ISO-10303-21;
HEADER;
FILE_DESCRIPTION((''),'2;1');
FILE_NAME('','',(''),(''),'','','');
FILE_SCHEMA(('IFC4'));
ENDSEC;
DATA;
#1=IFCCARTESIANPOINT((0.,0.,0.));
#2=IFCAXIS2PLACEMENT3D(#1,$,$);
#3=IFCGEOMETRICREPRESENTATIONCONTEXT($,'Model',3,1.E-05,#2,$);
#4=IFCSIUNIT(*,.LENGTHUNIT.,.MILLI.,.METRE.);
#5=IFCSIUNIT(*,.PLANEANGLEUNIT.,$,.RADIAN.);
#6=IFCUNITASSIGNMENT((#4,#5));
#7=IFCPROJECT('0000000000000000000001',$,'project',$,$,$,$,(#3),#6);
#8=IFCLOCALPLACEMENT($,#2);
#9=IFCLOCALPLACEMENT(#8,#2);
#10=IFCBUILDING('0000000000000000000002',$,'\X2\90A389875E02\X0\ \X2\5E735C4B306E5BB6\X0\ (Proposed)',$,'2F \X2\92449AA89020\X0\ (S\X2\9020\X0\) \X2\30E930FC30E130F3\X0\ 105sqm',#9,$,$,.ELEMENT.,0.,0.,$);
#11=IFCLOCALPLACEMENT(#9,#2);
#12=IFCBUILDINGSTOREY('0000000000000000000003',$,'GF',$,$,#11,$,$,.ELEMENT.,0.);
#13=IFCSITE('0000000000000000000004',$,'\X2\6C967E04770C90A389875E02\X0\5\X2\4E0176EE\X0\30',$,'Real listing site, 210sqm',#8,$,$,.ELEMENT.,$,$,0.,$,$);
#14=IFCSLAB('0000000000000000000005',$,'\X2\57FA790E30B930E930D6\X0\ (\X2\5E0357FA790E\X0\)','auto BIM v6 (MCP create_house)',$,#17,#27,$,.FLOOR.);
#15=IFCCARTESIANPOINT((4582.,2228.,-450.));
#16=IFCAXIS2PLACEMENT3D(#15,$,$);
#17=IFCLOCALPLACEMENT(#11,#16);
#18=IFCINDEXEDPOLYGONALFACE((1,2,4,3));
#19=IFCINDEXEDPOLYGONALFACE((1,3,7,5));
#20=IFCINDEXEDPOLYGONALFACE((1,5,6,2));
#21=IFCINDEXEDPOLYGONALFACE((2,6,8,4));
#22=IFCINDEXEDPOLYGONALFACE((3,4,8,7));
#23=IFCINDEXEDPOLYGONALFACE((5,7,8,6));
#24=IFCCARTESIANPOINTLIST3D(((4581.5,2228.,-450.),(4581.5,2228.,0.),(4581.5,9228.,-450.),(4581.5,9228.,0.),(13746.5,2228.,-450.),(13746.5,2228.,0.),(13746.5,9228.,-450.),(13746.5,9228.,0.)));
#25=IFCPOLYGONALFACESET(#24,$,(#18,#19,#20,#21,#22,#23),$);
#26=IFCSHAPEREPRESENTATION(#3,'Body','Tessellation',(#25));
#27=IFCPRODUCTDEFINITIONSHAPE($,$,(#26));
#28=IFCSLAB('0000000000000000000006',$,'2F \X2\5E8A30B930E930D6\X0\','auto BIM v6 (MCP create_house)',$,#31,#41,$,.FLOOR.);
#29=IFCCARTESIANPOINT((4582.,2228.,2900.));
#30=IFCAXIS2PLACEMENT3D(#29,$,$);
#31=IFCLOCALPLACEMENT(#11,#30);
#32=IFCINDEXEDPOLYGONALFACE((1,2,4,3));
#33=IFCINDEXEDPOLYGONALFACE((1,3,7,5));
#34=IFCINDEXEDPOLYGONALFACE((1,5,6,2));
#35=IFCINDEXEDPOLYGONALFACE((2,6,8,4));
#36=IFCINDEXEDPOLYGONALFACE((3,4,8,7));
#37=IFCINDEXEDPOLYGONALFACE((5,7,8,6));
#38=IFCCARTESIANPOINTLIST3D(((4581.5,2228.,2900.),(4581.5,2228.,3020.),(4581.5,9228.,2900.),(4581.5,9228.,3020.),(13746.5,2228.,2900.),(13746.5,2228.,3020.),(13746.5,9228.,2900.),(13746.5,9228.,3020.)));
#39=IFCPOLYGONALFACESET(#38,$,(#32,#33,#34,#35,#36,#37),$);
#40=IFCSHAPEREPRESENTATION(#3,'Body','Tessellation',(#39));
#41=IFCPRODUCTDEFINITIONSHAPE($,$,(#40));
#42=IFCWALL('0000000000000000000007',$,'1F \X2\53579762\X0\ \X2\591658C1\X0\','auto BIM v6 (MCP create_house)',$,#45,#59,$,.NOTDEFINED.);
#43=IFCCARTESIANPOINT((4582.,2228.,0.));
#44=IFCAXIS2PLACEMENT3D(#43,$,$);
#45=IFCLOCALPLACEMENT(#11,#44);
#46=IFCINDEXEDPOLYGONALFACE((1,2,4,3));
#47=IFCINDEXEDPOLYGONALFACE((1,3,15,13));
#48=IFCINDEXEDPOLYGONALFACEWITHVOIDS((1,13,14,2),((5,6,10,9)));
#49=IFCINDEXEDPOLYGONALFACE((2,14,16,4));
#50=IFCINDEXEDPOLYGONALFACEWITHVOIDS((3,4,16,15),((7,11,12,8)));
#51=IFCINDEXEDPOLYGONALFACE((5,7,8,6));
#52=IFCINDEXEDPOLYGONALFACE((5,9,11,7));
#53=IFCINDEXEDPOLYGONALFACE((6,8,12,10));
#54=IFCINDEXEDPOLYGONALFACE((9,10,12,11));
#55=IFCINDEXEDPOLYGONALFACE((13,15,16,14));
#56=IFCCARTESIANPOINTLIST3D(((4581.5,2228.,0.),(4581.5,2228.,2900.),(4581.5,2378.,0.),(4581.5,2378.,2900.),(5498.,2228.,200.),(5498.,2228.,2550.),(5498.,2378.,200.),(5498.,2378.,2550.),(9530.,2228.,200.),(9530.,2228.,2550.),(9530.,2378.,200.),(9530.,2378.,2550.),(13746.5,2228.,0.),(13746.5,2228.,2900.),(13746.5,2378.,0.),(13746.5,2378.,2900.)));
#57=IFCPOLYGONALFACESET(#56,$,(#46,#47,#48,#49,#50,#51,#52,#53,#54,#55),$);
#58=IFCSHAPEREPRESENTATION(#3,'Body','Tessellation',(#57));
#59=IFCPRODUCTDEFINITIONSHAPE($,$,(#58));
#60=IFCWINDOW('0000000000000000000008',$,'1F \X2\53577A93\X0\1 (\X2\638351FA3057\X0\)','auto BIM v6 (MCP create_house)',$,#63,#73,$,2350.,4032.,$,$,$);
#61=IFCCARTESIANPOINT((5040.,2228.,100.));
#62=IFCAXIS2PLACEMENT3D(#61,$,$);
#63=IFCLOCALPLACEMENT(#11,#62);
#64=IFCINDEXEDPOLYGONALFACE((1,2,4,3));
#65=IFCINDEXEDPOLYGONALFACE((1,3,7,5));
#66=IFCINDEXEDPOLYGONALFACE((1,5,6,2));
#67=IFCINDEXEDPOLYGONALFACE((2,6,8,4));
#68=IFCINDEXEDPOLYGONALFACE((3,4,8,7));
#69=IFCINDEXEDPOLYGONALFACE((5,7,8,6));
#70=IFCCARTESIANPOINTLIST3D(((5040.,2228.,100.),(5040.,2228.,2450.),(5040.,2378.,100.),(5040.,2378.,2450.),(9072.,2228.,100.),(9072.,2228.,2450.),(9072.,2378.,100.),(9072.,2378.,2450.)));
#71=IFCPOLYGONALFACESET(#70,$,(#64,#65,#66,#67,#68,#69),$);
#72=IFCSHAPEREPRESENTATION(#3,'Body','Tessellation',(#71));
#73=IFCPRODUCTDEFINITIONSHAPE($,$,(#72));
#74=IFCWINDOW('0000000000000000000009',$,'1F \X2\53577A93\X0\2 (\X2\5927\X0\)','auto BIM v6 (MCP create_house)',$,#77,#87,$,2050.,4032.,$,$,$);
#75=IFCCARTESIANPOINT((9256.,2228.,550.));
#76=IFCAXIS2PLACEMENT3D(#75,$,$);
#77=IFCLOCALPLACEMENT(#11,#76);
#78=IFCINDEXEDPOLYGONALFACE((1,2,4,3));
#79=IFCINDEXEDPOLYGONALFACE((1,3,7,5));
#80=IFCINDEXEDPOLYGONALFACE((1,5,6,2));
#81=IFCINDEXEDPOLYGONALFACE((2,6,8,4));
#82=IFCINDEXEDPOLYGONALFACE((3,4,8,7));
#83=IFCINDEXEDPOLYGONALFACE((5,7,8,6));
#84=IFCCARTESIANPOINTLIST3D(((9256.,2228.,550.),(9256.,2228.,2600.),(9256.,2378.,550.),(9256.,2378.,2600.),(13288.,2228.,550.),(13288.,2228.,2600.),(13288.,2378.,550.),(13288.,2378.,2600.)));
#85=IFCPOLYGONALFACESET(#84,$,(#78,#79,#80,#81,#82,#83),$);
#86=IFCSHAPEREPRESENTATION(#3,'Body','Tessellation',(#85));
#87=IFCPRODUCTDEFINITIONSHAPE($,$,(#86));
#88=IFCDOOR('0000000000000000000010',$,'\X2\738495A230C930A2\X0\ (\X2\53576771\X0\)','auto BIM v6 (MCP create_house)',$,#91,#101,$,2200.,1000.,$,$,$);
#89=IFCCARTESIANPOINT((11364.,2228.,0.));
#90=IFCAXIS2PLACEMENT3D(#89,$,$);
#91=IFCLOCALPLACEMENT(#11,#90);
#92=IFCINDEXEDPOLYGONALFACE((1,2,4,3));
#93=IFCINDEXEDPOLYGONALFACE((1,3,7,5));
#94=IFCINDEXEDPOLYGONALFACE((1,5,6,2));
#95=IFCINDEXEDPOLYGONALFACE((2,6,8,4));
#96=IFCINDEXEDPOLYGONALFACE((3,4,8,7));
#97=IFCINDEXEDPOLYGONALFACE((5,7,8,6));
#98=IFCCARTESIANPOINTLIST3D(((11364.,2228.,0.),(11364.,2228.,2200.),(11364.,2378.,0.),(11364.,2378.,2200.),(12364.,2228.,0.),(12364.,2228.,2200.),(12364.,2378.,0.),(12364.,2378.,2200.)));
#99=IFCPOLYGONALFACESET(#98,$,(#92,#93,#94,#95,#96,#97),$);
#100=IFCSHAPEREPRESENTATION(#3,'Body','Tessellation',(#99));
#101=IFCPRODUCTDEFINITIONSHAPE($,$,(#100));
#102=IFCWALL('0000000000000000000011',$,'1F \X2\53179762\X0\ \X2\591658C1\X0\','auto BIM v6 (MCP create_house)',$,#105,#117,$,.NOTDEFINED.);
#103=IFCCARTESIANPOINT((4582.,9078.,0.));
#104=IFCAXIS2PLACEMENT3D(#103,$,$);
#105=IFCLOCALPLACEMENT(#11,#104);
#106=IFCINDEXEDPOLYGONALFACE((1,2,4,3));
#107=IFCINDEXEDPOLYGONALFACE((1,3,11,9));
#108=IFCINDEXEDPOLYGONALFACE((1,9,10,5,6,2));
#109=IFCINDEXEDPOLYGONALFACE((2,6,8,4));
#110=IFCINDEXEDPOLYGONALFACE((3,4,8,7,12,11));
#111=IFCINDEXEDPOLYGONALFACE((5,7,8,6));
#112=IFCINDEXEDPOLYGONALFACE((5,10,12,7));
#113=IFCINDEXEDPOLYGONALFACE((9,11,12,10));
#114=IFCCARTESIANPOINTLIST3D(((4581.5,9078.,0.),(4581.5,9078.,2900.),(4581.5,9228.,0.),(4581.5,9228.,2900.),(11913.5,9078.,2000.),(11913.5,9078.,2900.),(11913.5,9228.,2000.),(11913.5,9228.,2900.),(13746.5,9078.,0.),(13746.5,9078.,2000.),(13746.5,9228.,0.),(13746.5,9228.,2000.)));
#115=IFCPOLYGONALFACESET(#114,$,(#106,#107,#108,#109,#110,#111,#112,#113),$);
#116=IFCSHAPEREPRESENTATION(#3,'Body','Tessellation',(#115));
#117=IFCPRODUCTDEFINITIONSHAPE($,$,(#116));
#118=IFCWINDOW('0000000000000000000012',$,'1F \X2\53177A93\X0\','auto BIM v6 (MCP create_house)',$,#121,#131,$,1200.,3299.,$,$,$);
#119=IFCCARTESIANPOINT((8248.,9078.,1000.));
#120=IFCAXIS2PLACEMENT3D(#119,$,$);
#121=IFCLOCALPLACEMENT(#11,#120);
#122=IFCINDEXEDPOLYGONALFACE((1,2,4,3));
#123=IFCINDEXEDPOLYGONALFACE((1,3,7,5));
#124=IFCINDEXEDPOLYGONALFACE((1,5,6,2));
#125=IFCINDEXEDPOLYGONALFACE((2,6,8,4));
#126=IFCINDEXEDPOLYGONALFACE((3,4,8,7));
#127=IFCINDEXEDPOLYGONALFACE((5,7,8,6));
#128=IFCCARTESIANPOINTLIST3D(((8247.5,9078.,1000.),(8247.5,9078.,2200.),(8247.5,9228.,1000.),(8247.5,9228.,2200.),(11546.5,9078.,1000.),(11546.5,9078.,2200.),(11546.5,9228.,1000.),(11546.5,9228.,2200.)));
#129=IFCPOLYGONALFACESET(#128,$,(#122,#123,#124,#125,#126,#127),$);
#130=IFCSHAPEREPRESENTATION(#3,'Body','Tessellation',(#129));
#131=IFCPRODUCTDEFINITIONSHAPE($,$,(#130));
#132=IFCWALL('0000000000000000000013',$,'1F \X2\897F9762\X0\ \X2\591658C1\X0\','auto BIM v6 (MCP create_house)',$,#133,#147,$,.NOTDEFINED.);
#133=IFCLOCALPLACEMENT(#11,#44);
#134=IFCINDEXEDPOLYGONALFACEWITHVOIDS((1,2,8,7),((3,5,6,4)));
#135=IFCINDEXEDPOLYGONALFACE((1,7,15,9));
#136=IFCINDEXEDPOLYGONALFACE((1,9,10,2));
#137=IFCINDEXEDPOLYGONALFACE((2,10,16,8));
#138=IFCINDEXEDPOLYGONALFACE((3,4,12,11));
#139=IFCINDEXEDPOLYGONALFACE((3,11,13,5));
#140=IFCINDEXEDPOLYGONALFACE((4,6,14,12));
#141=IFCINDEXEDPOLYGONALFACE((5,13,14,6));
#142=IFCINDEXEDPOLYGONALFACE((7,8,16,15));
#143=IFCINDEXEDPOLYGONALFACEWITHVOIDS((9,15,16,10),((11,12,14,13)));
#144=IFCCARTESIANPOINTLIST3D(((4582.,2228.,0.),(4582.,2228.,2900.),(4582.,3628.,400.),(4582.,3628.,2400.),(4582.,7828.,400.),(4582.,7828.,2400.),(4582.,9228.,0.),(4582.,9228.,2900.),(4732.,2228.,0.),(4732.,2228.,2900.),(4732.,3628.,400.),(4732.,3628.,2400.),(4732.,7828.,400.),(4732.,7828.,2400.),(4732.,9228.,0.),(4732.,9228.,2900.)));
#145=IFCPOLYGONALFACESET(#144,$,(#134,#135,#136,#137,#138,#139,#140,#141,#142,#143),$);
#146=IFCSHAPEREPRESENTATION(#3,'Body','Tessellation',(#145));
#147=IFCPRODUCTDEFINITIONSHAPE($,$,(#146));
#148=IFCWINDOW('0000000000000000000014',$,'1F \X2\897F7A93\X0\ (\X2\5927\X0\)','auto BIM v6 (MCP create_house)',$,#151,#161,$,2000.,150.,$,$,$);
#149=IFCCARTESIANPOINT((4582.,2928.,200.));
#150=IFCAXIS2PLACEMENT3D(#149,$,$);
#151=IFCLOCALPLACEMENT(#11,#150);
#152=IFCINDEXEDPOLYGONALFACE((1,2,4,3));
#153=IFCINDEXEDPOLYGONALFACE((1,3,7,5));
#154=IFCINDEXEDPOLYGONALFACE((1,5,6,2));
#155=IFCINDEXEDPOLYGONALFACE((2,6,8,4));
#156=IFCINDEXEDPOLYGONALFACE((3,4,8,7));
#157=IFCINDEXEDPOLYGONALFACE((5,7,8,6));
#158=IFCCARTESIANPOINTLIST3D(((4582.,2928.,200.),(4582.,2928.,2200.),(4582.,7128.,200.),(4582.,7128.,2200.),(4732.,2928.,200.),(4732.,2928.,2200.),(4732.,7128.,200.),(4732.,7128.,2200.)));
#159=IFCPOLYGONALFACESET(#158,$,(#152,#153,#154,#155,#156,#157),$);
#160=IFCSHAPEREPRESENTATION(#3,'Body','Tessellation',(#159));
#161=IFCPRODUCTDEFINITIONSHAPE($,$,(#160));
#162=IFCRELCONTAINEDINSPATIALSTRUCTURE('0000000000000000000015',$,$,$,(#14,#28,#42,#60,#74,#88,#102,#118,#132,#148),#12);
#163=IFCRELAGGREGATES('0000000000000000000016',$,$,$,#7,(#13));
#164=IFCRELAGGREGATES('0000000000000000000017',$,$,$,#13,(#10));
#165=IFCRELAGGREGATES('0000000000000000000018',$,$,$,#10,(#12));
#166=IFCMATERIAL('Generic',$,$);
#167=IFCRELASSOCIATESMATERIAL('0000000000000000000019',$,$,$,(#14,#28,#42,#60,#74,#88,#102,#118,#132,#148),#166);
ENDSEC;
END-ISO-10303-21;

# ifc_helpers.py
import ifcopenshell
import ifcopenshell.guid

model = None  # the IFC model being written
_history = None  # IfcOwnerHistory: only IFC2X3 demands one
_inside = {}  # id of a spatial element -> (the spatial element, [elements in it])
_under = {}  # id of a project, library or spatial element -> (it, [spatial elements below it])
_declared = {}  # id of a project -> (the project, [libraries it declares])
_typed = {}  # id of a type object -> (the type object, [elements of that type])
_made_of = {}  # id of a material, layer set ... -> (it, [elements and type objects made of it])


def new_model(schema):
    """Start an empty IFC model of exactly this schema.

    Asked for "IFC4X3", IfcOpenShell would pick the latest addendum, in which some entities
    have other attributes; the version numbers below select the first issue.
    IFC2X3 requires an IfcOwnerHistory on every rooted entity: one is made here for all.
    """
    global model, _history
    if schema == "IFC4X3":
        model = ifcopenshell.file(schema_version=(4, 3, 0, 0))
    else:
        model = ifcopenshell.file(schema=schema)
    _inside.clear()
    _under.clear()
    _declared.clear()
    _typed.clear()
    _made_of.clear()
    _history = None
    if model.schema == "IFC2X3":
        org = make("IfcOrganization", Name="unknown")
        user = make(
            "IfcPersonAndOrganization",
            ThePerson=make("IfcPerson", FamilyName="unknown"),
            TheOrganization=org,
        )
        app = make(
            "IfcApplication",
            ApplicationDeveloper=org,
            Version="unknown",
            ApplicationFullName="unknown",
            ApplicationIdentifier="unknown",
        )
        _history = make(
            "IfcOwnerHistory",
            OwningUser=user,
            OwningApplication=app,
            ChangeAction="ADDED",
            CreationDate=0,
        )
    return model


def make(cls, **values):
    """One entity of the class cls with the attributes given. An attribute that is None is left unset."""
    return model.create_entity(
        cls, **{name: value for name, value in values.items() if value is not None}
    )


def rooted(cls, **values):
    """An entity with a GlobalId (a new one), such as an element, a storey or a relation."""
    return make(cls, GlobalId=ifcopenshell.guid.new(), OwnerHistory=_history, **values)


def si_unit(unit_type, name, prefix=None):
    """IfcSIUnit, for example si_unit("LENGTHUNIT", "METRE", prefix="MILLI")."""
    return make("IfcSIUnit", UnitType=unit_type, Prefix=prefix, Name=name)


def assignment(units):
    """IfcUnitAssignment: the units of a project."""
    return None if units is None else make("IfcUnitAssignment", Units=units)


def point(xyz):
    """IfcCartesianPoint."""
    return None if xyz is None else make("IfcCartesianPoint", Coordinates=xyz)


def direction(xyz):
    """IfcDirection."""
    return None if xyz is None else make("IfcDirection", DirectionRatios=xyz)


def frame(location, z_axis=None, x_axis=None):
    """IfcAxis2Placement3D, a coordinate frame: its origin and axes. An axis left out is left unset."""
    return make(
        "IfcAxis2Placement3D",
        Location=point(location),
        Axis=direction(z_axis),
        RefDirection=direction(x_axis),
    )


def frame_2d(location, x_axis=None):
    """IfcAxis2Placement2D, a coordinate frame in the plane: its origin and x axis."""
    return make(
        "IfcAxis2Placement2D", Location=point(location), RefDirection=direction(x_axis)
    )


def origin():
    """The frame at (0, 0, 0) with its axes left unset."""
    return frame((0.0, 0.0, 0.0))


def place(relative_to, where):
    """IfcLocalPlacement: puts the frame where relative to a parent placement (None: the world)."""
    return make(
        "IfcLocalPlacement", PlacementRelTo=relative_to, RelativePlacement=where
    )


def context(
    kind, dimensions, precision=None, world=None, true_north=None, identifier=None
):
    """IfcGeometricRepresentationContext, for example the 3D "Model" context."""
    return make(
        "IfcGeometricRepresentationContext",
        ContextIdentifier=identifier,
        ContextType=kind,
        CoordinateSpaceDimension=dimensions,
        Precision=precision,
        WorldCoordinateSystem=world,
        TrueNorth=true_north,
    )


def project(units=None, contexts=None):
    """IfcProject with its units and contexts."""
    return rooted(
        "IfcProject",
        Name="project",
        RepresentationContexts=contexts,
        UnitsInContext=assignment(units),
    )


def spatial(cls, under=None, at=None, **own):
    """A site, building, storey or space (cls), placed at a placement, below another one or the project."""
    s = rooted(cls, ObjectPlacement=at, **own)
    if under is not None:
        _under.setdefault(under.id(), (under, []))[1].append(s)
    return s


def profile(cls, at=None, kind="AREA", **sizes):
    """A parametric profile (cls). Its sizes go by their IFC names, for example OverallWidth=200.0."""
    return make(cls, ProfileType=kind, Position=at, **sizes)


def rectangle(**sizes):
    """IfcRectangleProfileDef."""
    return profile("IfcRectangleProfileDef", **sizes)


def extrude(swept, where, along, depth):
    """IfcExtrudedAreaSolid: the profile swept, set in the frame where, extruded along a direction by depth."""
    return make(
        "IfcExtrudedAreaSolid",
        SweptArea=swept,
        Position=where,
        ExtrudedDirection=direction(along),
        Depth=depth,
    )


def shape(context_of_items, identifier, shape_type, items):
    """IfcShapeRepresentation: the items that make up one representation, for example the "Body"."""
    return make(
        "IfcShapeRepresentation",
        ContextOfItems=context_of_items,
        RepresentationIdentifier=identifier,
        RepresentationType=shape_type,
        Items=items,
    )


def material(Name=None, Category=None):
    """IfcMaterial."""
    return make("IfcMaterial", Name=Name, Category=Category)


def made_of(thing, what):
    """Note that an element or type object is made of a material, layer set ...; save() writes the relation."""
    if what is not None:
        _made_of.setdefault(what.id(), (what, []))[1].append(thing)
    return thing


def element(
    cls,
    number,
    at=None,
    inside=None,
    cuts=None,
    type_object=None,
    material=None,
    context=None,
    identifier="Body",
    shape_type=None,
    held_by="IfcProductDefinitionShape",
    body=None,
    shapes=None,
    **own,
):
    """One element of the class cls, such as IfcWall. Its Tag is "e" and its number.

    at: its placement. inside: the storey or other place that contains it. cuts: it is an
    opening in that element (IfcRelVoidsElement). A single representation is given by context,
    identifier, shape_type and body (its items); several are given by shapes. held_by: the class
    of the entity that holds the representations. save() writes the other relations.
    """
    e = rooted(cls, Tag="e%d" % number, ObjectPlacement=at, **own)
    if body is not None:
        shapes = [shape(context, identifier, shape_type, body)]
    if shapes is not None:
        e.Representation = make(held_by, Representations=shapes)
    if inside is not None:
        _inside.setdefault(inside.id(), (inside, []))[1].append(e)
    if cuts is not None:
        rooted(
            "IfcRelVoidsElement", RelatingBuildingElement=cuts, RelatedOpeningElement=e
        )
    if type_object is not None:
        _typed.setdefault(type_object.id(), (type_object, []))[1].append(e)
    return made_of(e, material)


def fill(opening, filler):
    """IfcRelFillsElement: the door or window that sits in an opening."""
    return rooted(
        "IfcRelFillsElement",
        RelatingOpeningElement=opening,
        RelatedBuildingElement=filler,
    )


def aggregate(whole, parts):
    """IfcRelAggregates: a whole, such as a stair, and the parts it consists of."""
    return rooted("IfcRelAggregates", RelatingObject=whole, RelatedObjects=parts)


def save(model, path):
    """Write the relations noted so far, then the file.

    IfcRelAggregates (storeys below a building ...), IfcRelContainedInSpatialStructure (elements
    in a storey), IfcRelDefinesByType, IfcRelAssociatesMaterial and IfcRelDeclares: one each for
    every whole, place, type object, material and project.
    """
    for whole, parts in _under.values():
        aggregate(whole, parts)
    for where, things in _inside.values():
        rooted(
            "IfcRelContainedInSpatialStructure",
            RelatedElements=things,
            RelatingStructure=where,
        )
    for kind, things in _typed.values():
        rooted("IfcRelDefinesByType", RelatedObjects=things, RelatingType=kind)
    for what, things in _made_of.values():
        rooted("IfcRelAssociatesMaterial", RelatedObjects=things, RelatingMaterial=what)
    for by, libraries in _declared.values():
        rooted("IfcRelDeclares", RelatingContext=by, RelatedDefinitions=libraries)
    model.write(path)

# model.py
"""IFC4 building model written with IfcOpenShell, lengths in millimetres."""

from ifc_helpers import new_model, si_unit, frame, frame_2d, origin, place, context, project, spatial, rectangle, extrude, material, element, fill, save


model = new_model("IFC4")

# Units and contexts
model_context = context("Model", 3, precision=1e-05, world=origin())
ifc_project = project(units=[si_unit("LENGTHUNIT", "METRE", prefix="MILLI"), si_unit("PLANEANGLEUNIT", "RADIAN")], contexts=[model_context])

# Site, building, storey
site_placement = place(None, origin())
site = spatial("IfcSite", under=ifc_project, at=site_placement, Name="沖縄県那覇市5丁目30", ObjectType="Real listing site, 210sqm", CompositionType="ELEMENT", RefElevation=0.0)
building_placement = place(site_placement, origin())
building = spatial("IfcBuilding", under=site, at=building_placement, Name="那覇市 平屋の家 (Proposed)", ObjectType="2F 鉄骨造 (S造) ラーメン 105sqm", CompositionType="ELEMENT", ElevationOfRefHeight=0.0, ElevationOfTerrain=0.0)
storey_placement = place(building_placement, origin())
storey = spatial("IfcBuildingStorey", under=building, at=storey_placement, Name="GF", CompositionType="ELEMENT", Elevation=0.0)

# Slabs
ifc_material = material(Name="Generic")
slab_1_placement = place(storey_placement, frame((4582.0, 2228.0, -450.0)))
element("IfcSlab", 1, at=slab_1_placement, inside=storey, material=ifc_material, Name="基礎スラブ (布基礎)", Description="auto BIM v6 (MCP create_house)", PredefinedType="FLOOR", context=model_context, shape_type="SweptSolid", body=[
    extrude(rectangle(XDim=9165.0, YDim=7000.0, at=frame_2d((4582.0, 3500.0))), frame((4582.0, 2228.0, -450.0)), (0.0, 0.0, 1.0), 450.0),
])
slab_2_placement = place(storey_placement, frame((4582.0, 2228.0, 2900.0)))
element("IfcSlab", 2, at=slab_2_placement, inside=storey, material=ifc_material, Name="2F 床スラブ", Description="auto BIM v6 (MCP create_house)", PredefinedType="FLOOR", context=model_context, shape_type="SweptSolid", body=[
    extrude(rectangle(XDim=9165.0, YDim=7000.0, at=frame_2d((4582.0, 3500.0))), frame((4582.0, 2228.0, 2900.0)), (0.0, 0.0, 1.0), 120.0),
])

# Wall, openings, windows, door
wall_1_placement = place(storey_placement, frame((4582.0, 2228.0, 0.0)))
wall_1 = element("IfcWall", 3, at=wall_1_placement, inside=storey, material=ifc_material, Name="1F 南面 外壁", Description="auto BIM v6 (MCP create_house)", PredefinedType="NOTDEFINED", context=model_context, shape_type="SweptSolid", body=[
    extrude(rectangle(XDim=9165.0, YDim=150.0, at=frame_2d((4582.0, 75.0))), frame((4582.0, 2228.0, 0.0)), (0.0, 0.0, 1.0), 2900.0),
])
opening_1_placement = place(storey_placement, frame((5040.0, 2228.0, 100.0)))
opening_1 = element("IfcOpeningElement", 4, at=opening_1_placement, cuts=wall_1, PredefinedType="NOTDEFINED", context=model_context, shape_type="SweptSolid", body=[
    extrude(rectangle(XDim=4032.0, YDim=150.0, at=frame_2d((2016.0, 75.0))), frame((5040.0, 2228.0, 100.0)), (0.0, 0.0, 1.0), 2350.0),
])
opening_2_placement = place(storey_placement, frame((9256.0, 2228.0, 550.0)))
opening_2 = element("IfcOpeningElement", 5, at=opening_2_placement, cuts=wall_1, PredefinedType="NOTDEFINED", context=model_context, shape_type="SweptSolid", body=[
    extrude(rectangle(XDim=4032.0, YDim=150.0, at=frame_2d((2016.0, 75.0))), frame((9256.0, 2228.0, 550.0)), (0.0, 0.0, 1.0), 2050.0),
])
opening_3_placement = place(storey_placement, frame((11364.0, 2228.0, 0.0)))
opening_3 = element("IfcOpeningElement", 6, at=opening_3_placement, cuts=wall_1, PredefinedType="NOTDEFINED", context=model_context, shape_type="SweptSolid", body=[
    extrude(rectangle(XDim=1000.0, YDim=150.0, at=frame_2d((500.0, 75.0))), frame((11364.0, 2228.0, 0.0)), (0.0, 0.0, 1.0), 2200.0),
])
window_1_placement = place(storey_placement, frame((5040.0, 2228.0, 100.0)))
window_1 = element("IfcWindow", 7, at=window_1_placement, inside=storey, material=ifc_material, Name="1F 南窓1 (掃出し)", Description="auto BIM v6 (MCP create_house)", OverallHeight=2350.0, OverallWidth=4032.0, context=model_context, shape_type="SweptSolid", body=[
    extrude(rectangle(XDim=4032.0, YDim=150.0, at=frame_2d((2016.0, 75.0))), frame((5040.0, 2228.0, 100.0)), (0.0, 0.0, 1.0), 2350.0),
])
fill(opening_1, window_1)
window_2_placement = place(storey_placement, frame((9256.0, 2228.0, 550.0)))
window_2 = element("IfcWindow", 8, at=window_2_placement, inside=storey, material=ifc_material, Name="1F 南窓2 (大)", Description="auto BIM v6 (MCP create_house)", OverallHeight=2050.0, OverallWidth=4032.0, context=model_context, shape_type="SweptSolid", body=[
    extrude(rectangle(XDim=4032.0, YDim=150.0, at=frame_2d((2016.0, 75.0))), frame((9256.0, 2228.0, 550.0)), (0.0, 0.0, 1.0), 2050.0),
])
fill(opening_2, window_2)
door_placement = place(storey_placement, frame((11364.0, 2228.0, 0.0)))
door = element("IfcDoor", 9, at=door_placement, inside=storey, material=ifc_material, Name="玄関ドア (南東)", Description="auto BIM v6 (MCP create_house)", OverallHeight=2200.0, OverallWidth=1000.0, context=model_context, shape_type="SweptSolid", body=[
    extrude(rectangle(XDim=1000.0, YDim=150.0, at=frame_2d((500.0, 75.0))), frame((11364.0, 2228.0, 0.0)), (0.0, 0.0, 1.0), 2200.0),
])
fill(opening_3, door)

# Walls, openings, windows
wall_2_placement = place(storey_placement, frame((4582.0, 9078.0, 0.0)))
wall_2 = element("IfcWall", 10, at=wall_2_placement, inside=storey, material=ifc_material, Name="1F 北面 外壁", Description="auto BIM v6 (MCP create_house)", PredefinedType="NOTDEFINED", context=model_context, shape_type="SweptSolid", body=[
    extrude(rectangle(XDim=9165.0, YDim=150.0, at=frame_2d((4582.0, 75.0))), frame((4582.0, 9078.0, 0.0)), (0.0, 0.0, 1.0), 2900.0),
])
opening_4_placement = place(storey_placement, frame((8248.0, 9078.0, 1000.0)))
opening_4 = element("IfcOpeningElement", 11, at=opening_4_placement, cuts=wall_2, PredefinedType="NOTDEFINED", context=model_context, shape_type="SweptSolid", body=[
    extrude(rectangle(XDim=3299.0, YDim=150.0, at=frame_2d((1649.0, 75.0))), frame((8248.0, 9078.0, 1000.0)), (0.0, 0.0, 1.0), 1200.0),
])
window_3_placement = place(storey_placement, frame((8248.0, 9078.0, 1000.0)))
window_3 = element("IfcWindow", 12, at=window_3_placement, inside=storey, material=ifc_material, Name="1F 北窓", Description="auto BIM v6 (MCP create_house)", OverallHeight=1200.0, OverallWidth=3299.0, context=model_context, shape_type="SweptSolid", body=[
    extrude(rectangle(XDim=3299.0, YDim=150.0, at=frame_2d((1649.0, 75.0))), frame((8248.0, 9078.0, 1000.0)), (0.0, 0.0, 1.0), 1200.0),
])
fill(opening_4, window_3)
wall_3_placement = place(storey_placement, frame((4582.0, 2228.0, 0.0)))
wall_3 = element("IfcWall", 13, at=wall_3_placement, inside=storey, material=ifc_material, Name="1F 西面 外壁", Description="auto BIM v6 (MCP create_house)", PredefinedType="NOTDEFINED", context=model_context, shape_type="SweptSolid", body=[
    extrude(rectangle(XDim=150.0, YDim=7000.0, at=frame_2d((75.0, 3500.0))), frame((4582.0, 2228.0, 0.0)), (0.0, 0.0, 1.0), 2900.0),
])
opening_5_placement = place(storey_placement, frame((4582.0, 2928.0, 200.0)))
opening_5 = element("IfcOpeningElement", 14, at=opening_5_placement, cuts=wall_3, PredefinedType="NOTDEFINED", context=model_context, shape_type="SweptSolid", body=[
    extrude(rectangle(XDim=150.0, YDim=4200.0, at=frame_2d((75.0, 2100.0))), frame((4582.0, 2928.0, 200.0)), (0.0, 0.0, 1.0), 2000.0),
])
window_4_placement = place(storey_placement, frame((4582.0, 2928.0, 200.0)))
window_4 = element("IfcWindow", 15, at=window_4_placement, inside=storey, material=ifc_material, Name="1F 西窓 (大)", Description="auto BIM v6 (MCP create_house)", OverallHeight=2000.0, OverallWidth=150.0, context=model_context, shape_type="SweptSolid", body=[
    extrude(rectangle(XDim=150.0, YDim=4200.0, at=frame_2d((75.0, 2100.0))), frame((4582.0, 2928.0, 200.0)), (0.0, 0.0, 1.0), 2000.0),
])
fill(opening_5, window_4)

save(model, "model.ifc")
